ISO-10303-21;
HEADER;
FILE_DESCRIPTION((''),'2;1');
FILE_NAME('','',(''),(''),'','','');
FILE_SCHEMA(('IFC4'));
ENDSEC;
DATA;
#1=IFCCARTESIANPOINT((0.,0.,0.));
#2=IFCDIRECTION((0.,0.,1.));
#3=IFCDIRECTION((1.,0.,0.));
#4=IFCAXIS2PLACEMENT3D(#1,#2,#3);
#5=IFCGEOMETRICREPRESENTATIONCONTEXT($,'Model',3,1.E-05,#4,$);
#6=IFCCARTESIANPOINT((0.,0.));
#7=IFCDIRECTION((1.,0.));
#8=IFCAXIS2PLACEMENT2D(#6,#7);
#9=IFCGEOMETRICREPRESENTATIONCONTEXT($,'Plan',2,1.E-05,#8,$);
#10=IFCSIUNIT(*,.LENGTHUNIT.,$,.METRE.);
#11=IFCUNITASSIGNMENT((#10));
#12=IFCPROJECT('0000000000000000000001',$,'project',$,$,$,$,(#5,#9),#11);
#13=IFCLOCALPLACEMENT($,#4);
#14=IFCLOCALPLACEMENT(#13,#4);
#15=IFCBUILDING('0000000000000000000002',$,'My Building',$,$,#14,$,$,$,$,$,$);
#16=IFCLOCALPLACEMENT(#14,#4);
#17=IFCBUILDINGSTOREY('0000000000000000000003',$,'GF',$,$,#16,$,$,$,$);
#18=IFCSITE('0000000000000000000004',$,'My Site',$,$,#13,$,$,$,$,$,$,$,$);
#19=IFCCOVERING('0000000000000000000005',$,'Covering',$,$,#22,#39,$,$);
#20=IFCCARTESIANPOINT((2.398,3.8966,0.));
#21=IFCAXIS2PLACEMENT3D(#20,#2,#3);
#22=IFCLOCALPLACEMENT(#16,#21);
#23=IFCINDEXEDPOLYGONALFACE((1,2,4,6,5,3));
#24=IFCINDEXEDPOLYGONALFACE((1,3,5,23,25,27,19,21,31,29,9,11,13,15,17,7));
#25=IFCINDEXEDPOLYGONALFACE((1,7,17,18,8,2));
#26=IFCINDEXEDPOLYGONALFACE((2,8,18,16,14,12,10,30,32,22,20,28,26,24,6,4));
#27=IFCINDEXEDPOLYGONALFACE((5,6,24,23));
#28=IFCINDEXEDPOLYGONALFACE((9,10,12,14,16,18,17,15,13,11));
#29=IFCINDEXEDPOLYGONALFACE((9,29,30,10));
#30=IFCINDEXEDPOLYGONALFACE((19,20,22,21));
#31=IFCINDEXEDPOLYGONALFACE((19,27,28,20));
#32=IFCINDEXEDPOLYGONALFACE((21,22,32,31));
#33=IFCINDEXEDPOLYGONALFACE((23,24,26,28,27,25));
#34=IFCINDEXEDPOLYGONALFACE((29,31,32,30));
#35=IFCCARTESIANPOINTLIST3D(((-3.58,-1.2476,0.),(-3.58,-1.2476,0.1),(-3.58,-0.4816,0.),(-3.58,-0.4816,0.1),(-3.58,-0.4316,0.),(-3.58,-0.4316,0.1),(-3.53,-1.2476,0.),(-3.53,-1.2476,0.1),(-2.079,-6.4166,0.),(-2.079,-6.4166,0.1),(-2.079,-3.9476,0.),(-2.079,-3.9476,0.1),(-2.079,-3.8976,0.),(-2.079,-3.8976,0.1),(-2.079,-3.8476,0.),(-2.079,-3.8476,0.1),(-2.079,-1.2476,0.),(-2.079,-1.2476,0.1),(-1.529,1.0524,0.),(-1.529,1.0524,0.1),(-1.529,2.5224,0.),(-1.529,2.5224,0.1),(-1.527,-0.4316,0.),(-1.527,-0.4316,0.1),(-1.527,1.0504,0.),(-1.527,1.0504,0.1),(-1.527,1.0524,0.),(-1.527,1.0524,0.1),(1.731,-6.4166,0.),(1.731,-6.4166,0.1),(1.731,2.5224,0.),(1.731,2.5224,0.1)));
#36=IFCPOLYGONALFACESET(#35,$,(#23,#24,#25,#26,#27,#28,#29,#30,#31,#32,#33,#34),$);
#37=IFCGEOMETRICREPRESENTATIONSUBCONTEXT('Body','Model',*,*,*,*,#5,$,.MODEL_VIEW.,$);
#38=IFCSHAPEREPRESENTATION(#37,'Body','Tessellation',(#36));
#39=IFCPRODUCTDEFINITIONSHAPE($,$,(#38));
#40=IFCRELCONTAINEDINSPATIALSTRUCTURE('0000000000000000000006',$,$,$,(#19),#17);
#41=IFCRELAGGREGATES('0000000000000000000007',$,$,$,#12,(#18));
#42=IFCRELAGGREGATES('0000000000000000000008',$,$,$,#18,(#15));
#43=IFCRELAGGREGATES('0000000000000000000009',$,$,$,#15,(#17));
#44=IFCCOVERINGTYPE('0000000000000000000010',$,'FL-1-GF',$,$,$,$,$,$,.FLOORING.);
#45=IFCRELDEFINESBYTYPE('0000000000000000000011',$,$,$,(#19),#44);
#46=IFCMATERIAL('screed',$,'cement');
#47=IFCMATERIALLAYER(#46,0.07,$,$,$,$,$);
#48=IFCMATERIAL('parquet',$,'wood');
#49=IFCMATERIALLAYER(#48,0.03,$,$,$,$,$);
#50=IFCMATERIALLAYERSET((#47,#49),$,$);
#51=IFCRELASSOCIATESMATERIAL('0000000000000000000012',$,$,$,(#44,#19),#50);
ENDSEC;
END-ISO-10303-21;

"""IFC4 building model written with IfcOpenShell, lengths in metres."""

from ifc_helpers import new_model, si_unit, frame, origin_with_axes, origin_2d_with_axis, place, context, subcontext, project, spatial, line, indexed_curve, outline, extrude, material, layer, layer_set, layer_usage, type_object, element, save


model = new_model("IFC4")

# Units and contexts
model_context = context("Model", 3, precision=1e-05, world=origin_with_axes())
plan_context = context("Plan", 2, precision=1e-05, world=origin_2d_with_axis())
body_context_1 = subcontext(model_context, "Body", "Model", "MODEL_VIEW")
ifc_project = project(units=[si_unit("LENGTHUNIT", "METRE")], contexts=[model_context, plan_context])

# Site, building, storey
site_placement = place(None, origin_with_axes())
site = spatial("IfcSite", under=ifc_project, at=site_placement, Name="My Site")
building_placement = place(site_placement, origin_with_axes())
building = spatial("IfcBuilding", under=site, at=building_placement, Name="My Building")
storey_placement = place(building_placement, origin_with_axes())
storey = spatial("IfcBuildingStorey", under=building, at=storey_placement, Name="GF")

# Covering
ifc_material_1 = material(Name="screed", Category="cement")
ifc_layer_1 = layer(ifc_material_1, 0.07)
ifc_material_2 = material(Name="parquet", Category="wood")
ifc_layer_2 = layer(ifc_material_2, 0.03)
ifc_layer_set_1 = layer_set([ifc_layer_1, ifc_layer_2])
ifc_layer_usage_1 = layer_usage(ifc_layer_set_1, "AXIS3", "POSITIVE", 0.0)
covering_type = type_object("IfcCoveringType", Name="FL-1-GF", PredefinedType="FLOORING", material=ifc_layer_set_1)
covering_placement = place(storey_placement, frame((2.398, 3.8966, 0.0), z_axis=(0.0, 0.0, 1.0), x_axis=(1.0, 0.0, 0.0)))
element("IfcCovering", 1, at=covering_placement, inside=storey, type_object=covering_type, material=ifc_layer_usage_1, Name="Covering", context=body_context_1, shape_type="SweptSolid", body=[
    extrude(outline(indexed_curve([(1.731, 2.5224), (1.731, -6.4166), (-2.079, -6.4166), (-2.079, -6.4166), (-2.079, -3.9476), (-2.079, -3.8976), (-2.079, -3.8476), (-2.079, -1.2476), (-3.53, -1.2476), (-3.58, -1.2476), (-3.58, -0.4816), (-3.58, -0.4316), (-1.527, -0.4316), (-1.527, 1.0504), (-1.527, 1.0524), (-1.529, 1.0524), (-1.529, 1.0524), (-1.529, 2.5224), (-1.529, 2.5224)], segments=[line(1, 2, 3, 4, 5, 6, 7, 8, 9, 10, 11, 12, 13, 14, 15, 16, 17, 18, 19, 1)])), origin_with_axes(), (0.0, 0.0, 1.0), 0.1),
])

save(model, "model.ifc")
